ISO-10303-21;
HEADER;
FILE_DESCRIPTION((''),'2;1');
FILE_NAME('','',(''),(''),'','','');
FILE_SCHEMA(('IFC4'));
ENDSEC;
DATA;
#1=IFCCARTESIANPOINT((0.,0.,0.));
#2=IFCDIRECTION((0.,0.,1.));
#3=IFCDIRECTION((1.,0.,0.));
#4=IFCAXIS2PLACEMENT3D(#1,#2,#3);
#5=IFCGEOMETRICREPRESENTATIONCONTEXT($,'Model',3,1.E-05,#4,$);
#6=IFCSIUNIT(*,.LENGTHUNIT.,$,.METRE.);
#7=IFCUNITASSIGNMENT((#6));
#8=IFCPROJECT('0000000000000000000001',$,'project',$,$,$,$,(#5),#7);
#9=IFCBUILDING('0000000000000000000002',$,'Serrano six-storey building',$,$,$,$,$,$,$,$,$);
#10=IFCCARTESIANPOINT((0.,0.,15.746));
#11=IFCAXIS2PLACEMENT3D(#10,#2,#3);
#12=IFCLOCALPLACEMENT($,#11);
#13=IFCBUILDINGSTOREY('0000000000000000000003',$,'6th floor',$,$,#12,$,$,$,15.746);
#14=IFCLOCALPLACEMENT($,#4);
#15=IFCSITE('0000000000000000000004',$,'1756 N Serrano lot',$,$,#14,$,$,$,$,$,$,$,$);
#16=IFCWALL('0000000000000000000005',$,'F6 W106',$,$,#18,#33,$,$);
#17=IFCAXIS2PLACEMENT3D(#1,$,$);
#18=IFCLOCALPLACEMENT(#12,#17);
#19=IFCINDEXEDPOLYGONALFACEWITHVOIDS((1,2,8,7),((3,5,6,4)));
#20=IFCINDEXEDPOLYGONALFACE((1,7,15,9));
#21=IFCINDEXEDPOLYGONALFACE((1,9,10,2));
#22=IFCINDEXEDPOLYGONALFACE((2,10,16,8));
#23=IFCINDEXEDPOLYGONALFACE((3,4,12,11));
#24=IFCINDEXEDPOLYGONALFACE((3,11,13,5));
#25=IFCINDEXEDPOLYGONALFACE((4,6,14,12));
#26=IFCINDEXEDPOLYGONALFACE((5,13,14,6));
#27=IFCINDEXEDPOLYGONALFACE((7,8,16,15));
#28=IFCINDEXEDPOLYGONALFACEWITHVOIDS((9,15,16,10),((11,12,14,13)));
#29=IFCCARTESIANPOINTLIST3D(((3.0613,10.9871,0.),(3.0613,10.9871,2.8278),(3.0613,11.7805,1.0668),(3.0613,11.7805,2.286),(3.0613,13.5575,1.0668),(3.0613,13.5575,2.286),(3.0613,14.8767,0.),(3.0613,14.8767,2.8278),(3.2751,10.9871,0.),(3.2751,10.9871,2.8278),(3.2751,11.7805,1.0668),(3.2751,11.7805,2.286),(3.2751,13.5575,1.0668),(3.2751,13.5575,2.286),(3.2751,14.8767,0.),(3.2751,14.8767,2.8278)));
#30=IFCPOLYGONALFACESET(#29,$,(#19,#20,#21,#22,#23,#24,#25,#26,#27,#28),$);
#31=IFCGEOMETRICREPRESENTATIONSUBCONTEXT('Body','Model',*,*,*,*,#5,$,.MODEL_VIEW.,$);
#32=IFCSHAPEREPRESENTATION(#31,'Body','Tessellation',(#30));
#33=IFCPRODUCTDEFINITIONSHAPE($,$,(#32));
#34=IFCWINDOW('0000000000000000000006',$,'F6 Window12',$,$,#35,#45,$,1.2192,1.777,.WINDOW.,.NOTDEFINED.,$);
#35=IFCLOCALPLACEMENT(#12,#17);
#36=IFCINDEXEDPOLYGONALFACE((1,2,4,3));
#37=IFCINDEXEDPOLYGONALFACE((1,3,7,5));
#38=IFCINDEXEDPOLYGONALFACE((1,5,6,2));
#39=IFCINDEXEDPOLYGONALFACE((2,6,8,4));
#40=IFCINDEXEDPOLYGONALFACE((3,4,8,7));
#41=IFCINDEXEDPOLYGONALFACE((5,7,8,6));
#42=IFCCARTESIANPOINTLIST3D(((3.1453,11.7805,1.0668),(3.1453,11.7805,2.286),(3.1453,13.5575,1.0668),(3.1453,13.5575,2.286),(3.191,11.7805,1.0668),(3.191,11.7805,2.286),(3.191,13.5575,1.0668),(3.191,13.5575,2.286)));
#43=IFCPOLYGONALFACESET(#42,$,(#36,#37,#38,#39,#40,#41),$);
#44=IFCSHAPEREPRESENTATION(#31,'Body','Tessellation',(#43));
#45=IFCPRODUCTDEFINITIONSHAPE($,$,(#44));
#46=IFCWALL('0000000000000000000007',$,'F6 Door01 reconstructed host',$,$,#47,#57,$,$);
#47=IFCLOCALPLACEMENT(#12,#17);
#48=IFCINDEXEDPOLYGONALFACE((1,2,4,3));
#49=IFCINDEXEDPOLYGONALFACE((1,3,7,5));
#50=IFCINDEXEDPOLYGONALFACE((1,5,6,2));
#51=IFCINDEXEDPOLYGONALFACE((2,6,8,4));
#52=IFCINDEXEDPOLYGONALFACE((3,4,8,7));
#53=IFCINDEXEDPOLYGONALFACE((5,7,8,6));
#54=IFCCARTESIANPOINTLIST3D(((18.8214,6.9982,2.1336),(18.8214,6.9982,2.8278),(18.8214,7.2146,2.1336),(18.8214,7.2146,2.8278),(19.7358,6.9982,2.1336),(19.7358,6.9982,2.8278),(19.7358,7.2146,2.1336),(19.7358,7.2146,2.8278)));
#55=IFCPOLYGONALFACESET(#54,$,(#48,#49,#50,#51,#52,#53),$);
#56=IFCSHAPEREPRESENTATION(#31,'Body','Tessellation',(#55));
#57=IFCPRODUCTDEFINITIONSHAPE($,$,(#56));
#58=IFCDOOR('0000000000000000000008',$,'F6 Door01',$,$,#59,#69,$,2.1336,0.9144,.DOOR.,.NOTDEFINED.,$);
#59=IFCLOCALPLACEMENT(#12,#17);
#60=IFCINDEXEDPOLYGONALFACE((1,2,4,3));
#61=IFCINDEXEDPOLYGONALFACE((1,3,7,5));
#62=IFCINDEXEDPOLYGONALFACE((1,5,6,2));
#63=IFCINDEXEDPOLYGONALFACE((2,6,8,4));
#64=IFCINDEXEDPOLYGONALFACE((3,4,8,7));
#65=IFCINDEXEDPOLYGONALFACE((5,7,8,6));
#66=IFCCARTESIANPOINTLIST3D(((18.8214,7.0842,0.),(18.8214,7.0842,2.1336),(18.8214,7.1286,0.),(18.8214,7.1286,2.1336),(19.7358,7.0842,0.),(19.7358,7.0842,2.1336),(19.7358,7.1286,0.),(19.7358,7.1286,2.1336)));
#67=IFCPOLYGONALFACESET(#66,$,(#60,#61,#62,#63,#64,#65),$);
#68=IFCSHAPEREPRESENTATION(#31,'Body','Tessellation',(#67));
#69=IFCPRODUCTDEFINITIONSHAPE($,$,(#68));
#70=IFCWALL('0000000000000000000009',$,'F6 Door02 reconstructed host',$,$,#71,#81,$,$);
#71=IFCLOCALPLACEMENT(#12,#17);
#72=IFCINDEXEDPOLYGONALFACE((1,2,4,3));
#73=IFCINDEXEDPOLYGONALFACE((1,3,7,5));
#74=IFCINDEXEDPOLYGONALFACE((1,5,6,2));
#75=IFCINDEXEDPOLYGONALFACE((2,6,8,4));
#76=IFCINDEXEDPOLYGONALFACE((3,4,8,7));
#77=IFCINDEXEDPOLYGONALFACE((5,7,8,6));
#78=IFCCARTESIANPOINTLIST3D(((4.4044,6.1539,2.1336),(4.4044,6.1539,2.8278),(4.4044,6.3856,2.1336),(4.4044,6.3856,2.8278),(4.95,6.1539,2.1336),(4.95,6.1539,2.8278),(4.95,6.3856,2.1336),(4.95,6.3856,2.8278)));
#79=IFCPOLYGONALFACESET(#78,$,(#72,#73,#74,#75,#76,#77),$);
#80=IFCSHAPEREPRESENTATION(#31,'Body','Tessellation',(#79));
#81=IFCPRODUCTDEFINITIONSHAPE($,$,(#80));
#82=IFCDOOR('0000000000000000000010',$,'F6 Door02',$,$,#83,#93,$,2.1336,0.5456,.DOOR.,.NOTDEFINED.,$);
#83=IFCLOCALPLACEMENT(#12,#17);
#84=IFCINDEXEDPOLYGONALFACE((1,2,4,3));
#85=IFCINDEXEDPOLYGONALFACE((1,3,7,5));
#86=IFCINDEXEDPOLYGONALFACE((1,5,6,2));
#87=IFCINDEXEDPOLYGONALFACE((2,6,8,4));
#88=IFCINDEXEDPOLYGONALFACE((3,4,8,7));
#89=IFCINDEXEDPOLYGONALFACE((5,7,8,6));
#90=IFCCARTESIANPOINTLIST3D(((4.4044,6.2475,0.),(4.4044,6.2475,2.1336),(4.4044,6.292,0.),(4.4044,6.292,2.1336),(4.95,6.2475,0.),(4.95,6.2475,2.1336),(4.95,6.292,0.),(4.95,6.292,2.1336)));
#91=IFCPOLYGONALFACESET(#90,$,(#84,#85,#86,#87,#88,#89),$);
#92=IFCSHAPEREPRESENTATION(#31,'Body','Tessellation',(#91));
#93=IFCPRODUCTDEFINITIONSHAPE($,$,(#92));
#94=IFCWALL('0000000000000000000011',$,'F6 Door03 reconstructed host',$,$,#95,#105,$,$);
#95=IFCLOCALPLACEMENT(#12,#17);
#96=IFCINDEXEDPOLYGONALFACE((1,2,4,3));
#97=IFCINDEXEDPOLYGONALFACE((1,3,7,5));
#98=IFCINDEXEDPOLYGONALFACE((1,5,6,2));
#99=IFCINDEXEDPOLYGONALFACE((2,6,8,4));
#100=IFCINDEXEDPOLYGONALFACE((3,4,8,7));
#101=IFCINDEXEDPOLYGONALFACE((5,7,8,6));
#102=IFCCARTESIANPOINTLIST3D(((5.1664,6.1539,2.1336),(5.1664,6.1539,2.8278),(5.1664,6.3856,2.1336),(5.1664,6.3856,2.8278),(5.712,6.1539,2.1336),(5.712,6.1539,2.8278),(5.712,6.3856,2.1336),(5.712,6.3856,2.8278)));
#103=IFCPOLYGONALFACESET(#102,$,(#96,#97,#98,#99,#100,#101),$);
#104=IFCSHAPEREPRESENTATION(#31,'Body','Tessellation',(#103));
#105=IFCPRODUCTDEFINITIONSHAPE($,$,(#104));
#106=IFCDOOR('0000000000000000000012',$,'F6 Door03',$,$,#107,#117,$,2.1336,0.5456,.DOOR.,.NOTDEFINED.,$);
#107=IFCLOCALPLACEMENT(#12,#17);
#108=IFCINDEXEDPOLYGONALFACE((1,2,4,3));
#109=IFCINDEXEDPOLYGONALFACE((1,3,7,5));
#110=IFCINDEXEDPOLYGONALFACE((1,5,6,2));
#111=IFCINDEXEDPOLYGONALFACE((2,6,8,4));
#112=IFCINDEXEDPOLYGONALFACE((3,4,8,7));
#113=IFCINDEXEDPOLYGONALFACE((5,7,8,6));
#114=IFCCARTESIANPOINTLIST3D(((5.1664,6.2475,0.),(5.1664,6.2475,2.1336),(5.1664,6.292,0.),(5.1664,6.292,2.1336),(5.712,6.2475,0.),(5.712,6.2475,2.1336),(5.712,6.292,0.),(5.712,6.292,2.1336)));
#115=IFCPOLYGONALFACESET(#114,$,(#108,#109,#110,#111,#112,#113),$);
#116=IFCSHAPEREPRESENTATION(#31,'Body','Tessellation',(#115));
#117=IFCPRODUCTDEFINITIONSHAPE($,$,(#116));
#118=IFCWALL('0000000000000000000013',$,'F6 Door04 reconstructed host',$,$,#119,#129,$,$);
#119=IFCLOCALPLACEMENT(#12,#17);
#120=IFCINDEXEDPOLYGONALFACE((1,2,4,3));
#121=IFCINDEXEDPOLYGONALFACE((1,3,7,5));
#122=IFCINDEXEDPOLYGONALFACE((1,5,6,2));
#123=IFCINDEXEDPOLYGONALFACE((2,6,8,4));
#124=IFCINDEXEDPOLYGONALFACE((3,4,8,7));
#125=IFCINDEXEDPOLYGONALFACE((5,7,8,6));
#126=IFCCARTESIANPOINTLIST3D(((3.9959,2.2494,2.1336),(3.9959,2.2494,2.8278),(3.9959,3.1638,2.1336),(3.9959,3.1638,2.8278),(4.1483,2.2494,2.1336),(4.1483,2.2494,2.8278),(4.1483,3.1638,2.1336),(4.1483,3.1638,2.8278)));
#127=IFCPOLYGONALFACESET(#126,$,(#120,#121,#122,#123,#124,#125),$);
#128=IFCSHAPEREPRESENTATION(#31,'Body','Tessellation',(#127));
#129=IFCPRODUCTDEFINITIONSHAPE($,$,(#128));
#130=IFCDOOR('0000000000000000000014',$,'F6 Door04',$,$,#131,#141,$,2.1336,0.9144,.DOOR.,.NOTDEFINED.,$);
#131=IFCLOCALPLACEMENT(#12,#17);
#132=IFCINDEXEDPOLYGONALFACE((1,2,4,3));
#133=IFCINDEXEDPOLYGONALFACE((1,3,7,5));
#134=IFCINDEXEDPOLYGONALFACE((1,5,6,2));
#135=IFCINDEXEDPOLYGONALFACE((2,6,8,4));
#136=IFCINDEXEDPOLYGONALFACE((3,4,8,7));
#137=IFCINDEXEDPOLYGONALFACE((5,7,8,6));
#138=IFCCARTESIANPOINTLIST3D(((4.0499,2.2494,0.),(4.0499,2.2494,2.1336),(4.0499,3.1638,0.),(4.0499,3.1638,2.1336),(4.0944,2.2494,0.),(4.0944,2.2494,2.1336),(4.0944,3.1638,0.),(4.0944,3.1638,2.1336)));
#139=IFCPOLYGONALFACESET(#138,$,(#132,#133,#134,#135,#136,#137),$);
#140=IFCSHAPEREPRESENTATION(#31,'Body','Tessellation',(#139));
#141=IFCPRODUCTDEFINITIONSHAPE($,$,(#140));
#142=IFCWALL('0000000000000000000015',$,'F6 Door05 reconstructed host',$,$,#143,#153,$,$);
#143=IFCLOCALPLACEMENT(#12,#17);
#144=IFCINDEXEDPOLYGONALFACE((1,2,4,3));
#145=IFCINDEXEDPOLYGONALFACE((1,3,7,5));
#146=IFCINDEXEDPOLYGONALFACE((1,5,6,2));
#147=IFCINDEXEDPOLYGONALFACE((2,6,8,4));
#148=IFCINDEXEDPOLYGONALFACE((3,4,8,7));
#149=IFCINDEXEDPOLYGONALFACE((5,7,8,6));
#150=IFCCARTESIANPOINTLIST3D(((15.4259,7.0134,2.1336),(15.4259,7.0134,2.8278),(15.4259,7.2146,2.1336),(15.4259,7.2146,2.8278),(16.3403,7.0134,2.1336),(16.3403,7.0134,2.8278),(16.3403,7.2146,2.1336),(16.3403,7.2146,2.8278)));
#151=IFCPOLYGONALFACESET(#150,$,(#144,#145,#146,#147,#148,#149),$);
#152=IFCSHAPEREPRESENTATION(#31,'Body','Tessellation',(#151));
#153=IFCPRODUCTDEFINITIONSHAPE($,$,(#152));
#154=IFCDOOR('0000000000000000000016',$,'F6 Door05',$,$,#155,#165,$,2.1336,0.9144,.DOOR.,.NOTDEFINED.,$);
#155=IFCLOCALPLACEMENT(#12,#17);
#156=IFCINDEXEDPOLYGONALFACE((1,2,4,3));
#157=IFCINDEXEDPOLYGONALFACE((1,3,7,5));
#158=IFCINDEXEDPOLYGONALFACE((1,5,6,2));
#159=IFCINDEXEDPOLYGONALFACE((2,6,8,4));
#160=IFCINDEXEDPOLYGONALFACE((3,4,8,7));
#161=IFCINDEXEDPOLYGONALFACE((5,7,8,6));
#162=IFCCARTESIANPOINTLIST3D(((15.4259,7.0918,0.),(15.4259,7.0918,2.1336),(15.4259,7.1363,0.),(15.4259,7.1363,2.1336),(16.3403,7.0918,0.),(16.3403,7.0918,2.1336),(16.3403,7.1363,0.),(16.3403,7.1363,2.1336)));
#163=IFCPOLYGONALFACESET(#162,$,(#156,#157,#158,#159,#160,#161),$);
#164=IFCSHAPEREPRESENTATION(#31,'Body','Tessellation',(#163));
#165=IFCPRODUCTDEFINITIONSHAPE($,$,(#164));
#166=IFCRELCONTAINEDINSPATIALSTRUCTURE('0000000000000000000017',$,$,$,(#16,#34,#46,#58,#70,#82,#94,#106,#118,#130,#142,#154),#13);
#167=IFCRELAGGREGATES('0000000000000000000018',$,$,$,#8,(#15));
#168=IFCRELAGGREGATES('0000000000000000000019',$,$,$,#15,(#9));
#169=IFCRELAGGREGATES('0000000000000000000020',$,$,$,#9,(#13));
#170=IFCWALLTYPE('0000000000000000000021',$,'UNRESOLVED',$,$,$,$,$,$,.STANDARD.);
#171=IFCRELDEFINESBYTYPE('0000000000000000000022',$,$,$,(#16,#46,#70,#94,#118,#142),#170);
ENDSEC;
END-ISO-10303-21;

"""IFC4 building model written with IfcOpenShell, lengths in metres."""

from ifc_helpers import new_model, si_unit, frame, origin_with_axes, place, context, subcontext, project, spatial, polyline, outline, extrude, type_object, element, fill, save


model = new_model("IFC4")

# Units and contexts
model_context = context("Model", 3, precision=1e-05, world=origin_with_axes())
body_context = subcontext(model_context, "Body", "Model", "MODEL_VIEW")
ifc_project = project(units=[si_unit("LENGTHUNIT", "METRE")], contexts=[model_context])

# Site, building, storey
site_placement = place(None, origin_with_axes())
site = spatial("IfcSite", under=ifc_project, at=site_placement, Name="1756 N Serrano lot")
building = spatial("IfcBuilding", under=site, Name="Serrano six-storey building")
storey_placement = place(None, frame((0.0, 0.0, 15.746), z_axis=(0.0, 0.0, 1.0), x_axis=(1.0, 0.0, 0.0)))
storey = spatial("IfcBuildingStorey", under=building, at=storey_placement, Name="6th floor", Elevation=15.746)

# Wall, opening, window
wall_type = type_object("IfcWallType", Name="UNRESOLVED", PredefinedType="STANDARD")
wall_1_placement = place(storey_placement, frame((0.0, 0.0, -15.746), z_axis=(0.0, 0.0, 1.0), x_axis=(1.0, 0.0, 0.0)))
wall_1 = element("IfcWall", 1, at=wall_1_placement, inside=storey, type_object=wall_type, Name="F6 W106", context=body_context, shape_type="SweptSolid", body=[
    extrude(outline(polyline([(3.0613, 14.8767), (3.2751, 14.8767), (3.2751, 10.9871), (3.0613, 10.9871), (3.0613, 14.8767)])), frame((0.0, 0.0, 15.746)), (0.0, 0.0, 1.0), 2.8278),
])
opening_1_placement = place(None, origin_with_axes())
opening_1 = element("IfcOpeningElement", 2, at=opening_1_placement, cuts=wall_1, PredefinedType="OPENING", context=body_context, shape_type="SweptSolid", body=[
    extrude(outline(polyline([(3.043, 13.5575), (3.2934, 13.5575), (3.2934, 11.7805), (3.043, 11.7805), (3.043, 13.5575)])), frame((0.0, 0.0, 16.8128)), (0.0, 0.0, 1.0), 1.2192),
])
window_placement = place(storey_placement, frame((0.0, 0.0, -15.746), z_axis=(0.0, 0.0, 1.0), x_axis=(1.0, 0.0, 0.0)))
window = element("IfcWindow", 3, at=window_placement, inside=storey, Name="F6 Window12", OverallHeight=1.2192, OverallWidth=1.777, PartitioningType="NOTDEFINED", PredefinedType="WINDOW", context=body_context, shape_type="SweptSolid", body=[
    extrude(outline(polyline([(3.1453, 13.5575), (3.191, 13.5575), (3.191, 11.7805), (3.1453, 11.7805), (3.1453, 13.5575)])), frame((0.0, 0.0, 16.8128)), (0.0, 0.0, 1.0), 1.2192),
])
fill(opening_1, window)

# Walls, openings, doors
wall_2_placement = place(storey_placement, frame((0.0, 0.0, -15.746), z_axis=(0.0, 0.0, 1.0), x_axis=(1.0, 0.0, 0.0)))
wall_2 = element("IfcWall", 4, at=wall_2_placement, inside=storey, type_object=wall_type, Name="F6 Door01 reconstructed host", context=body_context, shape_type="SweptSolid", body=[
    extrude(outline(polyline([(18.8214, 6.9982), (18.8214, 7.2146), (19.7358, 7.2146), (19.7358, 6.9982), (18.8214, 6.9982)])), frame((0.0, 0.0, 15.746)), (0.0, 0.0, 1.0), 2.8278),
])
opening_2_placement = place(None, origin_with_axes())
opening_2 = element("IfcOpeningElement", 5, at=opening_2_placement, cuts=wall_2, PredefinedType="OPENING", context=body_context, shape_type="SweptSolid", body=[
    extrude(outline(polyline([(18.8214, 6.9799), (18.8214, 7.2329), (19.7358, 7.2329), (19.7358, 6.9799), (18.8214, 6.9799)])), frame((0.0, 0.0, 15.746)), (0.0, 0.0, 1.0), 2.1336),
])
door_1_placement = place(storey_placement, frame((0.0, 0.0, -15.746), z_axis=(0.0, 0.0, 1.0), x_axis=(1.0, 0.0, 0.0)))
door_1 = element("IfcDoor", 6, at=door_1_placement, inside=storey, Name="F6 Door01", OperationType="NOTDEFINED", OverallHeight=2.1336, OverallWidth=0.9144, PredefinedType="DOOR", context=body_context, shape_type="SweptSolid", body=[
    extrude(outline(polyline([(18.8214, 7.0842), (18.8214, 7.1286), (19.7358, 7.1286), (19.7358, 7.0842), (18.8214, 7.0842)])), frame((0.0, 0.0, 15.746)), (0.0, 0.0, 1.0), 2.1336),
])
fill(opening_2, door_1)
wall_3_placement = place(storey_placement, frame((0.0, 0.0, -15.746), z_axis=(0.0, 0.0, 1.0), x_axis=(1.0, 0.0, 0.0)))
wall_3 = element("IfcWall", 7, at=wall_3_placement, inside=storey, type_object=wall_type, Name="F6 Door02 reconstructed host", context=body_context, shape_type="SweptSolid", body=[
    extrude(outline(polyline([(4.95, 6.3856), (4.95, 6.1539), (4.4044, 6.1539), (4.4044, 6.3856), (4.95, 6.3856)])), frame((0.0, 0.0, 15.746)), (0.0, 0.0, 1.0), 2.8278),
])
opening_3_placement = place(None, origin_with_axes())
opening_3 = element("IfcOpeningElement", 8, at=opening_3_placement, cuts=wall_3, PredefinedType="OPENING", context=body_context, shape_type="SweptSolid", body=[
    extrude(outline(polyline([(4.95, 6.4038), (4.95, 6.1356), (4.4044, 6.1356), (4.4044, 6.4038), (4.95, 6.4038)])), frame((0.0, 0.0, 15.746)), (0.0, 0.0, 1.0), 2.1336),
])
door_2_placement = place(storey_placement, frame((0.0, 0.0, -15.746), z_axis=(0.0, 0.0, 1.0), x_axis=(1.0, 0.0, 0.0)))
door_2 = element("IfcDoor", 9, at=door_2_placement, inside=storey, Name="F6 Door02", OperationType="NOTDEFINED", OverallHeight=2.1336, OverallWidth=0.5456, PredefinedType="DOOR", context=body_context, shape_type="SweptSolid", body=[
    extrude(outline(polyline([(4.95, 6.292), (4.95, 6.2475), (4.4044, 6.2475), (4.4044, 6.292), (4.95, 6.292)])), frame((0.0, 0.0, 15.746)), (0.0, 0.0, 1.0), 2.1336),
])
fill(opening_3, door_2)
wall_4_placement = place(storey_placement, frame((0.0, 0.0, -15.746), z_axis=(0.0, 0.0, 1.0), x_axis=(1.0, 0.0, 0.0)))
wall_4 = element("IfcWall", 10, at=wall_4_placement, inside=storey, type_object=wall_type, Name="F6 Door03 reconstructed host", context=body_context, shape_type="SweptSolid", body=[
    extrude(outline(polyline([(5.1664, 6.1539), (5.1664, 6.3856), (5.712, 6.3856), (5.712, 6.1539), (5.1664, 6.1539)])), frame((0.0, 0.0, 15.746)), (0.0, 0.0, 1.0), 2.8278),
])
opening_4_placement = place(None, origin_with_axes())
opening_4 = element("IfcOpeningElement", 11, at=opening_4_placement, cuts=wall_4, PredefinedType="OPENING", context=body_context, shape_type="SweptSolid", body=[
    extrude(outline(polyline([(5.1664, 6.1356), (5.1664, 6.4038), (5.712, 6.4038), (5.712, 6.1356), (5.1664, 6.1356)])), frame((0.0, 0.0, 15.746)), (0.0, 0.0, 1.0), 2.1336),
])
door_3_placement = place(storey_placement, frame((0.0, 0.0, -15.746), z_axis=(0.0, 0.0, 1.0), x_axis=(1.0, 0.0, 0.0)))
door_3 = element("IfcDoor", 12, at=door_3_placement, inside=storey, Name="F6 Door03", OperationType="NOTDEFINED", OverallHeight=2.1336, OverallWidth=0.5456, PredefinedType="DOOR", context=body_context, shape_type="SweptSolid", body=[
    extrude(outline(polyline([(5.1664, 6.2475), (5.1664, 6.292), (5.712, 6.292), (5.712, 6.2475), (5.1664, 6.2475)])), frame((0.0, 0.0, 15.746)), (0.0, 0.0, 1.0), 2.1336),
])
fill(opening_4, door_3)
wall_5_placement = place(storey_placement, frame((0.0, 0.0, -15.746), z_axis=(0.0, 0.0, 1.0), x_axis=(1.0, 0.0, 0.0)))
wall_5 = element("IfcWall", 13, at=wall_5_placement, inside=storey, type_object=wall_type, Name="F6 Door04 reconstructed host", context=body_context, shape_type="SweptSolid", body=[
    extrude(outline(polyline([(3.9959, 3.1638), (4.1483, 3.1638), (4.1483, 2.2494), (3.9959, 2.2494), (3.9959, 3.1638)])), frame((0.0, 0.0, 15.746)), (0.0, 0.0, 1.0), 2.8278),
])
opening_5_placement = place(None, origin_with_axes())
opening_5 = element("IfcOpeningElement", 14, at=opening_5_placement, cuts=wall_5, PredefinedType="OPENING", context=body_context, shape_type="SweptSolid", body=[
    extrude(outline(polyline([(3.9776, 3.1638), (4.1666, 3.1638), (4.1666, 2.2494), (3.9776, 2.2494), (3.9776, 3.1638)])), frame((0.0, 0.0, 15.746)), (0.0, 0.0, 1.0), 2.1336),
])
door_4_placement = place(storey_placement, frame((0.0, 0.0, -15.746), z_axis=(0.0, 0.0, 1.0), x_axis=(1.0, 0.0, 0.0)))
door_4 = element("IfcDoor", 15, at=door_4_placement, inside=storey, Name="F6 Door04", OperationType="NOTDEFINED", OverallHeight=2.1336, OverallWidth=0.9144, PredefinedType="DOOR", context=body_context, shape_type="SweptSolid", body=[
    extrude(outline(polyline([(4.0499, 3.1638), (4.0944, 3.1638), (4.0944, 2.2494), (4.0499, 2.2494), (4.0499, 3.1638)])), frame((0.0, 0.0, 15.746)), (0.0, 0.0, 1.0), 2.1336),
])
fill(opening_5, door_4)
wall_6_placement = place(storey_placement, frame((0.0, 0.0, -15.746), z_axis=(0.0, 0.0, 1.0), x_axis=(1.0, 0.0, 0.0)))
wall_6 = element("IfcWall", 16, at=wall_6_placement, inside=storey, type_object=wall_type, Name="F6 Door05 reconstructed host", context=body_context, shape_type="SweptSolid", body=[
    extrude(outline(polyline([(15.4259, 7.0134), (15.4259, 7.2146), (16.3403, 7.2146), (16.3403, 7.0134), (15.4259, 7.0134)])), frame((0.0, 0.0, 15.746)), (0.0, 0.0, 1.0), 2.8278),
])
opening_6_placement = place(None, origin_with_axes())
opening_6 = element("IfcOpeningElement", 17, at=opening_6_placement, cuts=wall_6, PredefinedType="OPENING", context=body_context, shape_type="SweptSolid", body=[
    extrude(outline(polyline([(15.4259, 6.9952), (15.4259, 7.2329), (16.3403, 7.2329), (16.3403, 6.9952), (15.4259, 6.9952)])), frame((0.0, 0.0, 15.746)), (0.0, 0.0, 1.0), 2.1336),
])
door_5_placement = place(storey_placement, frame((0.0, 0.0, -15.746), z_axis=(0.0, 0.0, 1.0), x_axis=(1.0, 0.0, 0.0)))
door_5 = element("IfcDoor", 18, at=door_5_placement, inside=storey, Name="F6 Door05", OperationType="NOTDEFINED", OverallHeight=2.1336, OverallWidth=0.9144, PredefinedType="DOOR", context=body_context, shape_type="SweptSolid", body=[
    extrude(outline(polyline([(15.4259, 7.0918), (15.4259, 7.1363), (16.3403, 7.1363), (16.3403, 7.0918), (15.4259, 7.0918)])), frame((0.0, 0.0, 15.746)), (0.0, 0.0, 1.0), 2.1336),
])
fill(opening_6, door_5)

save(model, "model.ifc")
